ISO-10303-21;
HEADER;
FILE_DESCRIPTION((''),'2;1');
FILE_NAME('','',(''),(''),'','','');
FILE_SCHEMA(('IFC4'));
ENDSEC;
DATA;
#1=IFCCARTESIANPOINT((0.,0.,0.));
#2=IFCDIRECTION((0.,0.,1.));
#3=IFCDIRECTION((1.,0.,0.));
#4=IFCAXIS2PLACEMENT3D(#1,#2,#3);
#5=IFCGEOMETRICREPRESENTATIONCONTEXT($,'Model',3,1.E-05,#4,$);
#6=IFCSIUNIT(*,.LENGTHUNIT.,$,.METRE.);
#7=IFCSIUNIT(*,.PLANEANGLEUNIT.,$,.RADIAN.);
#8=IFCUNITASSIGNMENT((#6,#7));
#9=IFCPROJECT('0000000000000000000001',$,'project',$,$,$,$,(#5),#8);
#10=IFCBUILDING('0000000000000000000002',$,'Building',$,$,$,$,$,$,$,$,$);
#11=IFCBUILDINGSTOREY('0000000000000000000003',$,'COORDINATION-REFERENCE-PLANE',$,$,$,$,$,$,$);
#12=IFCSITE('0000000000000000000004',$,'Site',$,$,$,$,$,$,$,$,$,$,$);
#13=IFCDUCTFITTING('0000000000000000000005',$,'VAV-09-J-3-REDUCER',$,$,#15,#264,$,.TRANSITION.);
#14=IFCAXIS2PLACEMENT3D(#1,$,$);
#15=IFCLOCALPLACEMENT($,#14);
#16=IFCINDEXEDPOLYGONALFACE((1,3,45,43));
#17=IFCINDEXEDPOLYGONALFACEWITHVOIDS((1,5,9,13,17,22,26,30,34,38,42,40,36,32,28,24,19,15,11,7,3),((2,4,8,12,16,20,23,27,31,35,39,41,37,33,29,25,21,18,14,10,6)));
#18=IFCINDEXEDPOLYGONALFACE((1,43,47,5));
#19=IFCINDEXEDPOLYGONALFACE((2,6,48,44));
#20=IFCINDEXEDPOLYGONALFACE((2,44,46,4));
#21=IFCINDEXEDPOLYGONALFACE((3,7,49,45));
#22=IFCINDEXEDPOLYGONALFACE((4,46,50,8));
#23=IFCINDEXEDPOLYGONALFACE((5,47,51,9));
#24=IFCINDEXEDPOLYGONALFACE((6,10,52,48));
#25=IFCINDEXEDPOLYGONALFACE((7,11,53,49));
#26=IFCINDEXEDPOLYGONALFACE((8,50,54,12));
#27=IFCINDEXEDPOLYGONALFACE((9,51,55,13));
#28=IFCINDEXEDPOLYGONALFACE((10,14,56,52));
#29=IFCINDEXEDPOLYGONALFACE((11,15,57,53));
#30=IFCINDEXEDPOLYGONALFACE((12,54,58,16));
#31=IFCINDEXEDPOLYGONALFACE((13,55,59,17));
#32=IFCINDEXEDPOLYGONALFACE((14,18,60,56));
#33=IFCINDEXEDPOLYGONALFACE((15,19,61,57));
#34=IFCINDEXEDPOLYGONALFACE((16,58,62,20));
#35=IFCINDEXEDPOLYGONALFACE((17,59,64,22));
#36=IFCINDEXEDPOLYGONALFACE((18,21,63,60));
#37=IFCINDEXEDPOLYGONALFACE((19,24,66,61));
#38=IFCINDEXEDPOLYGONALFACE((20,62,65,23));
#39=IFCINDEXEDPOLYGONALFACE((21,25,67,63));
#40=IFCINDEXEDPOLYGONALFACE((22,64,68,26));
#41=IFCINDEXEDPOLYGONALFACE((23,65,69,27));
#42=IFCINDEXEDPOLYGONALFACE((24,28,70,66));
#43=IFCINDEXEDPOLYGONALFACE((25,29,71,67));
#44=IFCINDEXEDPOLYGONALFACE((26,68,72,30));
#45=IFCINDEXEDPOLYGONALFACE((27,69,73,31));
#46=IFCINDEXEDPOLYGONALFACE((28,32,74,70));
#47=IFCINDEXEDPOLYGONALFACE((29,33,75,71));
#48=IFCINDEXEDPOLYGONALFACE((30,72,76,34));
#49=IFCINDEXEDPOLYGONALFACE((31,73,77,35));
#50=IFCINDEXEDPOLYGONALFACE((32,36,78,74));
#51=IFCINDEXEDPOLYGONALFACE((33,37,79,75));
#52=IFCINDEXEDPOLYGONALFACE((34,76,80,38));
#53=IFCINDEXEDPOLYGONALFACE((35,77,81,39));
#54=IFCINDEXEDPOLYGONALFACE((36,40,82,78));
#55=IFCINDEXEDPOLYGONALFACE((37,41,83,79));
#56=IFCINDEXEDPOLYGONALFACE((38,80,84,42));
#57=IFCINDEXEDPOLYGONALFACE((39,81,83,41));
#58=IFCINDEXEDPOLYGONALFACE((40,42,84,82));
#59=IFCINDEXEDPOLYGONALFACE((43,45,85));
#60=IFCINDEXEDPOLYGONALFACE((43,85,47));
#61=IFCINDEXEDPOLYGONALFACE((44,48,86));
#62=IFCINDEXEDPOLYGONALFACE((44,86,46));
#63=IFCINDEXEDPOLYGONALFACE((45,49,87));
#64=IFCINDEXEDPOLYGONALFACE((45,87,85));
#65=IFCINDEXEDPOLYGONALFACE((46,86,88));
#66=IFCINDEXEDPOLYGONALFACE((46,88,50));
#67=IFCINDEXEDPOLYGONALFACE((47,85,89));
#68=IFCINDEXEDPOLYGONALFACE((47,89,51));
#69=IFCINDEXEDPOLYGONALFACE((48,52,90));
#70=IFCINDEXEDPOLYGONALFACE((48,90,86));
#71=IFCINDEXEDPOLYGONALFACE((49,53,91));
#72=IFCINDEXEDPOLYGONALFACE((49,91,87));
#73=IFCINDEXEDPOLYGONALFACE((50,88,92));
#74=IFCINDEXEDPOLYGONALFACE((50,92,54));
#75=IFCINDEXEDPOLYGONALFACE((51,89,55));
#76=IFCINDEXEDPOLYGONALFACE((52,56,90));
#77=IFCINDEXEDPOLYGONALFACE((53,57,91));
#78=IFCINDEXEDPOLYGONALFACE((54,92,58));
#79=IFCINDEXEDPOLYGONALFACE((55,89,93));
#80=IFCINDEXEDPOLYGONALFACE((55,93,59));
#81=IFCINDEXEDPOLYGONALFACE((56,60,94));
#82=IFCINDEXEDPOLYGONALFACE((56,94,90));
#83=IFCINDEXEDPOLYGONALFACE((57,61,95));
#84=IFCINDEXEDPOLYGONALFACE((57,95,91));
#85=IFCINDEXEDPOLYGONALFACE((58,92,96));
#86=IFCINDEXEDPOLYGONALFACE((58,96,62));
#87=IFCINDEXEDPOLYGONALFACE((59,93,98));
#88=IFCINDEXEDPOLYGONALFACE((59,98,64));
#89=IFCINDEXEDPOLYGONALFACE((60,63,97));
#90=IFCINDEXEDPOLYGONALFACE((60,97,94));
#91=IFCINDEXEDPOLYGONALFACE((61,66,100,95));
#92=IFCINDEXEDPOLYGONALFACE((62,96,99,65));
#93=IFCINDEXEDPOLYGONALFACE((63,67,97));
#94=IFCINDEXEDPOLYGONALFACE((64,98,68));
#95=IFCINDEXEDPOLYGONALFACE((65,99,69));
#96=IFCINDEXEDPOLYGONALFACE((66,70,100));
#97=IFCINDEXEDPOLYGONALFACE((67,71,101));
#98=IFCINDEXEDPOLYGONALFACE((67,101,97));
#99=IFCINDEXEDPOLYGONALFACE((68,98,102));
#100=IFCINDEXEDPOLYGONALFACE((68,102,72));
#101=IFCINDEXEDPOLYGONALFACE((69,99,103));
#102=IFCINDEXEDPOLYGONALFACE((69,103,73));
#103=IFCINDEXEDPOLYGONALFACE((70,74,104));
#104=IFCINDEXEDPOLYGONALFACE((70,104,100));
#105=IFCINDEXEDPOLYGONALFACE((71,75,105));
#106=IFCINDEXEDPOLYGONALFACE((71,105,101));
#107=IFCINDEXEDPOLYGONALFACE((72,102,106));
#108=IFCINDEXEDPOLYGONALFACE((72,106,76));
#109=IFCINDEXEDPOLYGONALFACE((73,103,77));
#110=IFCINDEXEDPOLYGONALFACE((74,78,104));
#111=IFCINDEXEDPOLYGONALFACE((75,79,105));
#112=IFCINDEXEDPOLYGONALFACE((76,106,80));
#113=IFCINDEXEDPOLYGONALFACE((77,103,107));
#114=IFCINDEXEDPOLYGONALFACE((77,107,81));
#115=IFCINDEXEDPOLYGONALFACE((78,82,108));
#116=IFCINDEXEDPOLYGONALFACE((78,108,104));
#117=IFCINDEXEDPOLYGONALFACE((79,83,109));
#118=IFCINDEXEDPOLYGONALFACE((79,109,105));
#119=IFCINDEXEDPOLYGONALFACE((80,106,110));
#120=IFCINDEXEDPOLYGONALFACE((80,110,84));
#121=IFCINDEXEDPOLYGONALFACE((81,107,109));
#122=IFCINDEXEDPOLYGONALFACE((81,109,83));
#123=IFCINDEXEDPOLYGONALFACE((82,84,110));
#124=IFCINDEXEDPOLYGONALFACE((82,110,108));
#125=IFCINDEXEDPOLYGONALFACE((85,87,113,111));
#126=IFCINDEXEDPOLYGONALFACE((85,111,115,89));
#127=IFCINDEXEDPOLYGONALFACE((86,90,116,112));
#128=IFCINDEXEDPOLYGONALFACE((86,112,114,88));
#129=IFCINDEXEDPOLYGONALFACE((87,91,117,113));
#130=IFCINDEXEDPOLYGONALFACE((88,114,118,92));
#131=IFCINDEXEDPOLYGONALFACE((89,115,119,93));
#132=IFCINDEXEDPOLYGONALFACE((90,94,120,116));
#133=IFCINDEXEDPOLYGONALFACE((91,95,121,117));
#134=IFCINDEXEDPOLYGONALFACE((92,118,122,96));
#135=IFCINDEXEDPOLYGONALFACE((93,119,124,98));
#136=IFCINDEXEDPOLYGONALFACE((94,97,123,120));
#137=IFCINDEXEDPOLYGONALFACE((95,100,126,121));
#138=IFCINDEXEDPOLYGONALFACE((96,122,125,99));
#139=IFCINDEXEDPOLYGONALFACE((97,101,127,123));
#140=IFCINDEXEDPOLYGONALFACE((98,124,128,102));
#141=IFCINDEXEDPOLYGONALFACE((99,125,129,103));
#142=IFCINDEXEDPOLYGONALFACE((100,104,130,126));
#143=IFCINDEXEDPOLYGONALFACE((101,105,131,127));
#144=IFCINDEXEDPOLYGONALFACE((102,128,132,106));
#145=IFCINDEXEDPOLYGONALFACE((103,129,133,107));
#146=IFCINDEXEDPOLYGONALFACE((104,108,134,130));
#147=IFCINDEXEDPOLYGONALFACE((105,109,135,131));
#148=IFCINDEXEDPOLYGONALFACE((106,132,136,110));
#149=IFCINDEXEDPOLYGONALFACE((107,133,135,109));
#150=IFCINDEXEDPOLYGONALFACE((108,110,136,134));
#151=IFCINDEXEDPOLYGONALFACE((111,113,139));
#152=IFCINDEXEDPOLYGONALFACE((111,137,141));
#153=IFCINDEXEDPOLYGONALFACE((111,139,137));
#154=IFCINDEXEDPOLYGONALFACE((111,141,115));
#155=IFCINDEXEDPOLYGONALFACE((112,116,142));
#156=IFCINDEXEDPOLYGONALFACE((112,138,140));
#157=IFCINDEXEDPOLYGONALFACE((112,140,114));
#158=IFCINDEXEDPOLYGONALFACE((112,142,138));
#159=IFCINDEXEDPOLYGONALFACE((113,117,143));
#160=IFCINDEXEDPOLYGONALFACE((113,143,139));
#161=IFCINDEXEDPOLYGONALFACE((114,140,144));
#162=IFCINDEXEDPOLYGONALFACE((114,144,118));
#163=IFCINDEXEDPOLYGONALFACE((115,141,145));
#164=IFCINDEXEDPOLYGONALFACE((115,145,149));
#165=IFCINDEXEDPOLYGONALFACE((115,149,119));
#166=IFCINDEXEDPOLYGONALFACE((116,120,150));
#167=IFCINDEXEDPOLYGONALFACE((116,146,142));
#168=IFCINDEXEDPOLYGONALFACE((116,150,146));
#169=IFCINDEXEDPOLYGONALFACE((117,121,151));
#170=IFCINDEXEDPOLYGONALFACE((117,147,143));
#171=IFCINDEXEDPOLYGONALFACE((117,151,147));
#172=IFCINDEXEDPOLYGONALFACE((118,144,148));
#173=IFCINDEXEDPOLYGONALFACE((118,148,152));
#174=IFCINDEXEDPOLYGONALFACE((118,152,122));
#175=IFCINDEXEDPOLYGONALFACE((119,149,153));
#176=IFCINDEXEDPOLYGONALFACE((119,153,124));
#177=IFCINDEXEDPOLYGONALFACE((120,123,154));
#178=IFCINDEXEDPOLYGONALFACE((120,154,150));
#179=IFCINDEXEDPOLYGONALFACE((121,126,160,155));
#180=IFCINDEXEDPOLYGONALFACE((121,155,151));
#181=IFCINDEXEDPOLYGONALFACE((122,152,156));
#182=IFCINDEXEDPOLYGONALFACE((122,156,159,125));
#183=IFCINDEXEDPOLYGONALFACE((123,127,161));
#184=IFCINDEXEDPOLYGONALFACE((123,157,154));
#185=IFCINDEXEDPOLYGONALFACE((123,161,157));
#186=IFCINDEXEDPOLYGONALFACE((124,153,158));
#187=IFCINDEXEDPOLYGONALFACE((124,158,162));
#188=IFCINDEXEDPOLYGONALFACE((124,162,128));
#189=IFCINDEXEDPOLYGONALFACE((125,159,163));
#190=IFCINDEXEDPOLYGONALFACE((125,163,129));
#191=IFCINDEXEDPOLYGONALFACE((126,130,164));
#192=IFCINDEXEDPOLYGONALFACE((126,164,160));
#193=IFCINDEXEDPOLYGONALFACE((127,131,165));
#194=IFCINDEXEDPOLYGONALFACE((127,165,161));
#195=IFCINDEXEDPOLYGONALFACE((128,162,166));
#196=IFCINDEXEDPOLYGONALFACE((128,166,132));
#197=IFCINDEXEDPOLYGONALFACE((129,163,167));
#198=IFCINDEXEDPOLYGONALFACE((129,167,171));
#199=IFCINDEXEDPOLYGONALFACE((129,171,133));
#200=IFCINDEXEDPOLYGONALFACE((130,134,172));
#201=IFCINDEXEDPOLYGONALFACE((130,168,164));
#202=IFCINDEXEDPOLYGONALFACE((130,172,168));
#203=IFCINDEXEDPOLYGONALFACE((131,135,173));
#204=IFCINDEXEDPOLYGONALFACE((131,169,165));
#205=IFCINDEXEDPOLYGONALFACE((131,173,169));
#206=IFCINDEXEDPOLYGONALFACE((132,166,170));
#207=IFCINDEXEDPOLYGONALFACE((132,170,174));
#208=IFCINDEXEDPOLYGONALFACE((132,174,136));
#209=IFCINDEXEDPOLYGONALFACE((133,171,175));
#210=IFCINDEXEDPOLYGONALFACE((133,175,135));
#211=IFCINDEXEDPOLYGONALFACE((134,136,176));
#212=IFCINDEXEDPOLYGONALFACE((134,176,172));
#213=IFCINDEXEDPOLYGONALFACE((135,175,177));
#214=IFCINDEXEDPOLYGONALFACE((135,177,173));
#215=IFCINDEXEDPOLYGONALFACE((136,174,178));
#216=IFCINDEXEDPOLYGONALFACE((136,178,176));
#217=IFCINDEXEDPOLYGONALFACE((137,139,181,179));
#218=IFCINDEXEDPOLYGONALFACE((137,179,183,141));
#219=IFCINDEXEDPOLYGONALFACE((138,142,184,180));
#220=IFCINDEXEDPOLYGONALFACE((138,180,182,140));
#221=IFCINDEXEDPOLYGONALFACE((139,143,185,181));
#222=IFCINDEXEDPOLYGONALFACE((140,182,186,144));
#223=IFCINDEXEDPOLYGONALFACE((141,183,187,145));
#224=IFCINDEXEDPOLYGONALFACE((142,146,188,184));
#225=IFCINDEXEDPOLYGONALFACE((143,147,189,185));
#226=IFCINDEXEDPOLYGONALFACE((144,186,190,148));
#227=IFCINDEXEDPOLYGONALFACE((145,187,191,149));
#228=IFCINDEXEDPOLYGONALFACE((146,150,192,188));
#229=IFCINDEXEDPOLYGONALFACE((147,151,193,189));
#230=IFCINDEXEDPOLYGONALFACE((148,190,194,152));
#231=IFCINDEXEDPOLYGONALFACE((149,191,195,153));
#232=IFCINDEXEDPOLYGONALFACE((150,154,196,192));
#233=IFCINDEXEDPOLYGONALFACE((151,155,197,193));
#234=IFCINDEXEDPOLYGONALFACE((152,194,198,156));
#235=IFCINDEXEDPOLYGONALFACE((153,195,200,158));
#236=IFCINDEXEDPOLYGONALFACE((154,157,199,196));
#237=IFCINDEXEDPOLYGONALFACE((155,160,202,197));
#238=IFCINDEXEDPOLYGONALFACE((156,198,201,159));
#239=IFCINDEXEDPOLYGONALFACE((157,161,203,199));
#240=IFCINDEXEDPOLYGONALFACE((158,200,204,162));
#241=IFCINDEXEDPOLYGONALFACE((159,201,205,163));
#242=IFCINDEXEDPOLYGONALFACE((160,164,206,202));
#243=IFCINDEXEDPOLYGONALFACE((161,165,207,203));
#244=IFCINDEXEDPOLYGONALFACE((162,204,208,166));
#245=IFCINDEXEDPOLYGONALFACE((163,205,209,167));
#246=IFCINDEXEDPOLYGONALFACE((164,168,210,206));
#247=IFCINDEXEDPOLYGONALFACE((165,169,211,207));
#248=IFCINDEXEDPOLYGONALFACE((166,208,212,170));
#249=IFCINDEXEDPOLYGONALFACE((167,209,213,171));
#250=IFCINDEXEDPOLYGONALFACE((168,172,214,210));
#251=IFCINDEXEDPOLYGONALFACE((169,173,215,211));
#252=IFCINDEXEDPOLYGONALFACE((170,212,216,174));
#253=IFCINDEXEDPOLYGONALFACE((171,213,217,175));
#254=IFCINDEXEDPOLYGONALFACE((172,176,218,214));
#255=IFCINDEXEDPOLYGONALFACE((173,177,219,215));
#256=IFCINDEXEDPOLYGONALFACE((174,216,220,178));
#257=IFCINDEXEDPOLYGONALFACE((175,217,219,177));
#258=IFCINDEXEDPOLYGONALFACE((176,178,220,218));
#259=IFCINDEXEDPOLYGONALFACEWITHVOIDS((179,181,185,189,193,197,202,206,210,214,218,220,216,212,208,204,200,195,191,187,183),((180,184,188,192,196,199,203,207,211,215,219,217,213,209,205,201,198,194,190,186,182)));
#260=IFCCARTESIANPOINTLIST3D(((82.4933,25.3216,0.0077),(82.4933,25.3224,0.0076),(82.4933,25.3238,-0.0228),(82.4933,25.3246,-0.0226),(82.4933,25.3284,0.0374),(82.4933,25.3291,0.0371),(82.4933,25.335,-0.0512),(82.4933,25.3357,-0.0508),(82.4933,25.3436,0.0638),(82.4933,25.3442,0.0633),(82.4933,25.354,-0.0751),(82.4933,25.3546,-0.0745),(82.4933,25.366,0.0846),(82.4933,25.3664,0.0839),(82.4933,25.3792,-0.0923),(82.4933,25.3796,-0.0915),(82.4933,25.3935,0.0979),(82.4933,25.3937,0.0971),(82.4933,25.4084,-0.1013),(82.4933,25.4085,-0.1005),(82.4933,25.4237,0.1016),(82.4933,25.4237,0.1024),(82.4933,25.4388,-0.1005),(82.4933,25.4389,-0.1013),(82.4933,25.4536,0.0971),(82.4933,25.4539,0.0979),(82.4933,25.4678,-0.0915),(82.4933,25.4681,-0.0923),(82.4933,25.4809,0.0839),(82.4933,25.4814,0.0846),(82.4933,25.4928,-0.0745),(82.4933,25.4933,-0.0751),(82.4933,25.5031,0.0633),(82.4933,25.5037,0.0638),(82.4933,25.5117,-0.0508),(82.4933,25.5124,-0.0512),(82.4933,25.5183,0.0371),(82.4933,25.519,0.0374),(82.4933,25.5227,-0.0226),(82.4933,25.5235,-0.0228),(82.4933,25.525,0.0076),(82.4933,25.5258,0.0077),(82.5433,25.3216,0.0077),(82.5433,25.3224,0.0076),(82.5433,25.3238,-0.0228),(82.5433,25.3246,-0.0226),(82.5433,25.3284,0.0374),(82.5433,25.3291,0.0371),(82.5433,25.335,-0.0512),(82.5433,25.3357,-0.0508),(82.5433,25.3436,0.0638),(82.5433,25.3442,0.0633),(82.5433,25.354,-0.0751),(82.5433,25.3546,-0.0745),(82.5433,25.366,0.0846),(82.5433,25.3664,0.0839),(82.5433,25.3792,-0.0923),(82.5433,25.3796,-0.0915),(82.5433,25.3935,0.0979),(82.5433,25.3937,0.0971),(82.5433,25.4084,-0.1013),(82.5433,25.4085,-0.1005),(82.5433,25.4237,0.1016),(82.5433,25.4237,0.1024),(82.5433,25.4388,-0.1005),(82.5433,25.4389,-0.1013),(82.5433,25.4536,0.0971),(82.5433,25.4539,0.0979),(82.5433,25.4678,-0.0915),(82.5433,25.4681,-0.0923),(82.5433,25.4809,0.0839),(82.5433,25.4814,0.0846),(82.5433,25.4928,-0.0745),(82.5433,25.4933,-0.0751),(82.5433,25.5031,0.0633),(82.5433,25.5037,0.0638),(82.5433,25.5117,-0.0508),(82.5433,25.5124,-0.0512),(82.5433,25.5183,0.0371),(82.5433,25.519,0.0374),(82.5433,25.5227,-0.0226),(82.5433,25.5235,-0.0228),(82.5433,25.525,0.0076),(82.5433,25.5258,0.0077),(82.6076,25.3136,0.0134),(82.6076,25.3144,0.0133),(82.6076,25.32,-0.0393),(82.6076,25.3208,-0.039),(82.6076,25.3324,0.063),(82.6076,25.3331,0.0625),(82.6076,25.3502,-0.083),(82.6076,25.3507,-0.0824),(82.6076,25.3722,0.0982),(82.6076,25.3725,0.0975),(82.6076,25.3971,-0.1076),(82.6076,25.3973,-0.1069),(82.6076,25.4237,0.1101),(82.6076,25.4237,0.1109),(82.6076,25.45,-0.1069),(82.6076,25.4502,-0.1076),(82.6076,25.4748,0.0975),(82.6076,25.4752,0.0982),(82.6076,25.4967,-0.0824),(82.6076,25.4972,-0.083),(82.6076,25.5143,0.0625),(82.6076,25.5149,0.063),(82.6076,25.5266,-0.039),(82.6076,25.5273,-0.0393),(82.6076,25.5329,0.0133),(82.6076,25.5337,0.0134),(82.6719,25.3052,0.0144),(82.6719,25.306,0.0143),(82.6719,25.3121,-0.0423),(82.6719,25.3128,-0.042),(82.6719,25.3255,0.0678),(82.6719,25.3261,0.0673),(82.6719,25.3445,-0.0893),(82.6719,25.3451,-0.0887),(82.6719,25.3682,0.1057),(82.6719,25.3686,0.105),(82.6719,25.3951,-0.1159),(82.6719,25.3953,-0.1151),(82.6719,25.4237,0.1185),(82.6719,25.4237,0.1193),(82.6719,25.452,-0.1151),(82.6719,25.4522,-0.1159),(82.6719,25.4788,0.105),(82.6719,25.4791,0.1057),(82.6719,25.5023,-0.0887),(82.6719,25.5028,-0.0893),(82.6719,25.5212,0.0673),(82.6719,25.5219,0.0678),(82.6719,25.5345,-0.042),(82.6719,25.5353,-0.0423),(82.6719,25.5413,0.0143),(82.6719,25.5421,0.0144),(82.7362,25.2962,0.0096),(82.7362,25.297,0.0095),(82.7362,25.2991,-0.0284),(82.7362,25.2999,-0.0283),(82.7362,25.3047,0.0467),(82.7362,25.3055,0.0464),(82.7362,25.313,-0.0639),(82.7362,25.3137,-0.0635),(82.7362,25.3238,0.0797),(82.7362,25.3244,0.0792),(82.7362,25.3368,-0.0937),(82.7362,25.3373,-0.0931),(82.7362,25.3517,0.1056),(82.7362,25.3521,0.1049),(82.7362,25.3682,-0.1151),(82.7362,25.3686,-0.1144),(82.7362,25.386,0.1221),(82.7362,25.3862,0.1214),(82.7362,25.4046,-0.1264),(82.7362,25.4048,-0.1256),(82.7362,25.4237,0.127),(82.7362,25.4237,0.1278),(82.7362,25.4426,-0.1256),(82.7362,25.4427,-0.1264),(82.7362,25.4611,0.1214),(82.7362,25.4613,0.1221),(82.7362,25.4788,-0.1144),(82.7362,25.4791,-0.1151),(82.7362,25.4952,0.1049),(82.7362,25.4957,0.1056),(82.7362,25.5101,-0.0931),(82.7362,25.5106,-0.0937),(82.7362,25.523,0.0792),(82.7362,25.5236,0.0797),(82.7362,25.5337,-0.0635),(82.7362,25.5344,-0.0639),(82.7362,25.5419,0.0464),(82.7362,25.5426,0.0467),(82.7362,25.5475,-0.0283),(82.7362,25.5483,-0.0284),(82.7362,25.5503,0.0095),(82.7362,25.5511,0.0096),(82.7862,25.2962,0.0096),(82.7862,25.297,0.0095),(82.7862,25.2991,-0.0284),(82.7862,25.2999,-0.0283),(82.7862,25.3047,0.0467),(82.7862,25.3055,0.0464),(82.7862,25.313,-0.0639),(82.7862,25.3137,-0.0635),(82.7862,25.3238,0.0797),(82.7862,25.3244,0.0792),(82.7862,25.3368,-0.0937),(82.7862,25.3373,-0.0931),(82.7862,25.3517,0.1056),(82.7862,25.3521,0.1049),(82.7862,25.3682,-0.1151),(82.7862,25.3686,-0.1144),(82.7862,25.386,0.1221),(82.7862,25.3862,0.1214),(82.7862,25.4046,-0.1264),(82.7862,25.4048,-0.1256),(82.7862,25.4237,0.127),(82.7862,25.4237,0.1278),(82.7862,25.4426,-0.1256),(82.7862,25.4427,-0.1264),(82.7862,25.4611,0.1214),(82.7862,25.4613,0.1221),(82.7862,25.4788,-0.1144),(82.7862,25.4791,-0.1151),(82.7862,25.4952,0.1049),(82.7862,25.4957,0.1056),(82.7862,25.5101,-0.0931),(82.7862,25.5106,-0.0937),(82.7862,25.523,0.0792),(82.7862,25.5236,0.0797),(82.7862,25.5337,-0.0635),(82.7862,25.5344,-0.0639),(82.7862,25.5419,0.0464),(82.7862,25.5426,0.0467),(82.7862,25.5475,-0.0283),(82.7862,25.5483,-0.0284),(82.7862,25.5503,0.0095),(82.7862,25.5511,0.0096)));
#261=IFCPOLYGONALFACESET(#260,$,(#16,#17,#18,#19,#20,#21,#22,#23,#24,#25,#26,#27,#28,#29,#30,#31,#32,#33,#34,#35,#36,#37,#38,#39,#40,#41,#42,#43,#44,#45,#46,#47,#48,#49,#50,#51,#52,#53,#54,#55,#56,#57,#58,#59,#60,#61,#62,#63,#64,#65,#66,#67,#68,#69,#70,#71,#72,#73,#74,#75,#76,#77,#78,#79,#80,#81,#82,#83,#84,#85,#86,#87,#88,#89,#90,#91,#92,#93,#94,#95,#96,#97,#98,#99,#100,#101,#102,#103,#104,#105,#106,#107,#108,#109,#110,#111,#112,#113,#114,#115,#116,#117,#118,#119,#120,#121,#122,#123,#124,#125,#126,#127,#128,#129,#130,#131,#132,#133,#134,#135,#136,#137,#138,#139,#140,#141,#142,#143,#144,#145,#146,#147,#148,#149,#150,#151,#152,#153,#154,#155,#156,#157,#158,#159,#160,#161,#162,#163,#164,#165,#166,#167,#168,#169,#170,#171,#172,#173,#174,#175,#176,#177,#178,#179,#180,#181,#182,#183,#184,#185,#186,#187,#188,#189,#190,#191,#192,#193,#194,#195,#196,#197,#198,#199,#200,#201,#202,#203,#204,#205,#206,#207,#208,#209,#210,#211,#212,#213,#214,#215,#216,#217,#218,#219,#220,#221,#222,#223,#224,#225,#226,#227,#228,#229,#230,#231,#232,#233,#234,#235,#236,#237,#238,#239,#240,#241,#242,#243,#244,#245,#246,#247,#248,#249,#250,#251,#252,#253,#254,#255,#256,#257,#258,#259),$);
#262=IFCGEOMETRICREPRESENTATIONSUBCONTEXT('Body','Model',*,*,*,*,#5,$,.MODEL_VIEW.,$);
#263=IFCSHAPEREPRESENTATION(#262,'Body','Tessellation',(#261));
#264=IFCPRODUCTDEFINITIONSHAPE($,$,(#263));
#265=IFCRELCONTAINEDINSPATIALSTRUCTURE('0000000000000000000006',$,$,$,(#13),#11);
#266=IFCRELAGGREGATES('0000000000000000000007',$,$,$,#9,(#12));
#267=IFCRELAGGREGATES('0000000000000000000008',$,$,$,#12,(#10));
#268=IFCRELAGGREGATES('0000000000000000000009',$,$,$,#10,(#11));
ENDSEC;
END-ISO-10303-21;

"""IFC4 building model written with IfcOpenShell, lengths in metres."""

from ifc_helpers import new_model, entity, si_unit, frame, origin_with_axes, place, context, subcontext, project, spatial, element, save


model = new_model("IFC4")

# Units and contexts
model_context = context("Model", 3, precision=1e-05, world=origin_with_axes())
body_context_1 = subcontext(model_context, "Body", "Model", "MODEL_VIEW")
ifc_project = project(units=[si_unit("LENGTHUNIT", "METRE"), si_unit("PLANEANGLEUNIT", "RADIAN")], contexts=[model_context])

# Site, building, storey
site = spatial("IfcSite", under=ifc_project, Name="Site")
building = spatial("IfcBuilding", under=site, Name="Building")
storey = spatial("IfcBuildingStorey", under=building, Name="COORDINATION-REFERENCE-PLANE")

# Duct fitting
for number, where, z_axis, x_axis, name in (
    (1, (82.7862, 25.4237, 0.0), (0.0, -1.0, 0.0), (0.0, 0.0, 1.0), "VAV-09-J-3-REDUCER"),
):
    element("IfcDuctFitting", number, at=place(None, frame(where, z_axis=z_axis, x_axis=x_axis)), inside=storey, Name=name, PredefinedType="TRANSITION", context=body_context_1, shape_type="SweptSolid", body=[
        entity("IfcRevolvedAreaSolid", entity("IfcArbitraryClosedProfileDef", "AREA", None, entity("IfcPolyline", [entity("IfcCartesianPoint", [0.1278, 0.0]), entity("IfcCartesianPoint", [0.1278, 0.05]), entity("IfcCartesianPoint", [0.1024, 0.2429]), entity("IfcCartesianPoint", [0.1024, 0.2929]), entity("IfcCartesianPoint", [0.1016, 0.2929]), entity("IfcCartesianPoint", [0.1016, 0.2429]), entity("IfcCartesianPoint", [0.127, 0.05]), entity("IfcCartesianPoint", [0.127, 0.0]), entity("IfcCartesianPoint", [0.1278, 0.0])])), entity("IfcAxis2Placement3D", entity("IfcCartesianPoint", [0.0, 0.0, 0.0])), entity("IfcAxis1Placement", entity("IfcCartesianPoint", [0.0, 0.0, 0.0]), entity("IfcDirection", [0.0, 1.0, 0.0])), 6.283185),
    ])

save(model, "model.ifc")
